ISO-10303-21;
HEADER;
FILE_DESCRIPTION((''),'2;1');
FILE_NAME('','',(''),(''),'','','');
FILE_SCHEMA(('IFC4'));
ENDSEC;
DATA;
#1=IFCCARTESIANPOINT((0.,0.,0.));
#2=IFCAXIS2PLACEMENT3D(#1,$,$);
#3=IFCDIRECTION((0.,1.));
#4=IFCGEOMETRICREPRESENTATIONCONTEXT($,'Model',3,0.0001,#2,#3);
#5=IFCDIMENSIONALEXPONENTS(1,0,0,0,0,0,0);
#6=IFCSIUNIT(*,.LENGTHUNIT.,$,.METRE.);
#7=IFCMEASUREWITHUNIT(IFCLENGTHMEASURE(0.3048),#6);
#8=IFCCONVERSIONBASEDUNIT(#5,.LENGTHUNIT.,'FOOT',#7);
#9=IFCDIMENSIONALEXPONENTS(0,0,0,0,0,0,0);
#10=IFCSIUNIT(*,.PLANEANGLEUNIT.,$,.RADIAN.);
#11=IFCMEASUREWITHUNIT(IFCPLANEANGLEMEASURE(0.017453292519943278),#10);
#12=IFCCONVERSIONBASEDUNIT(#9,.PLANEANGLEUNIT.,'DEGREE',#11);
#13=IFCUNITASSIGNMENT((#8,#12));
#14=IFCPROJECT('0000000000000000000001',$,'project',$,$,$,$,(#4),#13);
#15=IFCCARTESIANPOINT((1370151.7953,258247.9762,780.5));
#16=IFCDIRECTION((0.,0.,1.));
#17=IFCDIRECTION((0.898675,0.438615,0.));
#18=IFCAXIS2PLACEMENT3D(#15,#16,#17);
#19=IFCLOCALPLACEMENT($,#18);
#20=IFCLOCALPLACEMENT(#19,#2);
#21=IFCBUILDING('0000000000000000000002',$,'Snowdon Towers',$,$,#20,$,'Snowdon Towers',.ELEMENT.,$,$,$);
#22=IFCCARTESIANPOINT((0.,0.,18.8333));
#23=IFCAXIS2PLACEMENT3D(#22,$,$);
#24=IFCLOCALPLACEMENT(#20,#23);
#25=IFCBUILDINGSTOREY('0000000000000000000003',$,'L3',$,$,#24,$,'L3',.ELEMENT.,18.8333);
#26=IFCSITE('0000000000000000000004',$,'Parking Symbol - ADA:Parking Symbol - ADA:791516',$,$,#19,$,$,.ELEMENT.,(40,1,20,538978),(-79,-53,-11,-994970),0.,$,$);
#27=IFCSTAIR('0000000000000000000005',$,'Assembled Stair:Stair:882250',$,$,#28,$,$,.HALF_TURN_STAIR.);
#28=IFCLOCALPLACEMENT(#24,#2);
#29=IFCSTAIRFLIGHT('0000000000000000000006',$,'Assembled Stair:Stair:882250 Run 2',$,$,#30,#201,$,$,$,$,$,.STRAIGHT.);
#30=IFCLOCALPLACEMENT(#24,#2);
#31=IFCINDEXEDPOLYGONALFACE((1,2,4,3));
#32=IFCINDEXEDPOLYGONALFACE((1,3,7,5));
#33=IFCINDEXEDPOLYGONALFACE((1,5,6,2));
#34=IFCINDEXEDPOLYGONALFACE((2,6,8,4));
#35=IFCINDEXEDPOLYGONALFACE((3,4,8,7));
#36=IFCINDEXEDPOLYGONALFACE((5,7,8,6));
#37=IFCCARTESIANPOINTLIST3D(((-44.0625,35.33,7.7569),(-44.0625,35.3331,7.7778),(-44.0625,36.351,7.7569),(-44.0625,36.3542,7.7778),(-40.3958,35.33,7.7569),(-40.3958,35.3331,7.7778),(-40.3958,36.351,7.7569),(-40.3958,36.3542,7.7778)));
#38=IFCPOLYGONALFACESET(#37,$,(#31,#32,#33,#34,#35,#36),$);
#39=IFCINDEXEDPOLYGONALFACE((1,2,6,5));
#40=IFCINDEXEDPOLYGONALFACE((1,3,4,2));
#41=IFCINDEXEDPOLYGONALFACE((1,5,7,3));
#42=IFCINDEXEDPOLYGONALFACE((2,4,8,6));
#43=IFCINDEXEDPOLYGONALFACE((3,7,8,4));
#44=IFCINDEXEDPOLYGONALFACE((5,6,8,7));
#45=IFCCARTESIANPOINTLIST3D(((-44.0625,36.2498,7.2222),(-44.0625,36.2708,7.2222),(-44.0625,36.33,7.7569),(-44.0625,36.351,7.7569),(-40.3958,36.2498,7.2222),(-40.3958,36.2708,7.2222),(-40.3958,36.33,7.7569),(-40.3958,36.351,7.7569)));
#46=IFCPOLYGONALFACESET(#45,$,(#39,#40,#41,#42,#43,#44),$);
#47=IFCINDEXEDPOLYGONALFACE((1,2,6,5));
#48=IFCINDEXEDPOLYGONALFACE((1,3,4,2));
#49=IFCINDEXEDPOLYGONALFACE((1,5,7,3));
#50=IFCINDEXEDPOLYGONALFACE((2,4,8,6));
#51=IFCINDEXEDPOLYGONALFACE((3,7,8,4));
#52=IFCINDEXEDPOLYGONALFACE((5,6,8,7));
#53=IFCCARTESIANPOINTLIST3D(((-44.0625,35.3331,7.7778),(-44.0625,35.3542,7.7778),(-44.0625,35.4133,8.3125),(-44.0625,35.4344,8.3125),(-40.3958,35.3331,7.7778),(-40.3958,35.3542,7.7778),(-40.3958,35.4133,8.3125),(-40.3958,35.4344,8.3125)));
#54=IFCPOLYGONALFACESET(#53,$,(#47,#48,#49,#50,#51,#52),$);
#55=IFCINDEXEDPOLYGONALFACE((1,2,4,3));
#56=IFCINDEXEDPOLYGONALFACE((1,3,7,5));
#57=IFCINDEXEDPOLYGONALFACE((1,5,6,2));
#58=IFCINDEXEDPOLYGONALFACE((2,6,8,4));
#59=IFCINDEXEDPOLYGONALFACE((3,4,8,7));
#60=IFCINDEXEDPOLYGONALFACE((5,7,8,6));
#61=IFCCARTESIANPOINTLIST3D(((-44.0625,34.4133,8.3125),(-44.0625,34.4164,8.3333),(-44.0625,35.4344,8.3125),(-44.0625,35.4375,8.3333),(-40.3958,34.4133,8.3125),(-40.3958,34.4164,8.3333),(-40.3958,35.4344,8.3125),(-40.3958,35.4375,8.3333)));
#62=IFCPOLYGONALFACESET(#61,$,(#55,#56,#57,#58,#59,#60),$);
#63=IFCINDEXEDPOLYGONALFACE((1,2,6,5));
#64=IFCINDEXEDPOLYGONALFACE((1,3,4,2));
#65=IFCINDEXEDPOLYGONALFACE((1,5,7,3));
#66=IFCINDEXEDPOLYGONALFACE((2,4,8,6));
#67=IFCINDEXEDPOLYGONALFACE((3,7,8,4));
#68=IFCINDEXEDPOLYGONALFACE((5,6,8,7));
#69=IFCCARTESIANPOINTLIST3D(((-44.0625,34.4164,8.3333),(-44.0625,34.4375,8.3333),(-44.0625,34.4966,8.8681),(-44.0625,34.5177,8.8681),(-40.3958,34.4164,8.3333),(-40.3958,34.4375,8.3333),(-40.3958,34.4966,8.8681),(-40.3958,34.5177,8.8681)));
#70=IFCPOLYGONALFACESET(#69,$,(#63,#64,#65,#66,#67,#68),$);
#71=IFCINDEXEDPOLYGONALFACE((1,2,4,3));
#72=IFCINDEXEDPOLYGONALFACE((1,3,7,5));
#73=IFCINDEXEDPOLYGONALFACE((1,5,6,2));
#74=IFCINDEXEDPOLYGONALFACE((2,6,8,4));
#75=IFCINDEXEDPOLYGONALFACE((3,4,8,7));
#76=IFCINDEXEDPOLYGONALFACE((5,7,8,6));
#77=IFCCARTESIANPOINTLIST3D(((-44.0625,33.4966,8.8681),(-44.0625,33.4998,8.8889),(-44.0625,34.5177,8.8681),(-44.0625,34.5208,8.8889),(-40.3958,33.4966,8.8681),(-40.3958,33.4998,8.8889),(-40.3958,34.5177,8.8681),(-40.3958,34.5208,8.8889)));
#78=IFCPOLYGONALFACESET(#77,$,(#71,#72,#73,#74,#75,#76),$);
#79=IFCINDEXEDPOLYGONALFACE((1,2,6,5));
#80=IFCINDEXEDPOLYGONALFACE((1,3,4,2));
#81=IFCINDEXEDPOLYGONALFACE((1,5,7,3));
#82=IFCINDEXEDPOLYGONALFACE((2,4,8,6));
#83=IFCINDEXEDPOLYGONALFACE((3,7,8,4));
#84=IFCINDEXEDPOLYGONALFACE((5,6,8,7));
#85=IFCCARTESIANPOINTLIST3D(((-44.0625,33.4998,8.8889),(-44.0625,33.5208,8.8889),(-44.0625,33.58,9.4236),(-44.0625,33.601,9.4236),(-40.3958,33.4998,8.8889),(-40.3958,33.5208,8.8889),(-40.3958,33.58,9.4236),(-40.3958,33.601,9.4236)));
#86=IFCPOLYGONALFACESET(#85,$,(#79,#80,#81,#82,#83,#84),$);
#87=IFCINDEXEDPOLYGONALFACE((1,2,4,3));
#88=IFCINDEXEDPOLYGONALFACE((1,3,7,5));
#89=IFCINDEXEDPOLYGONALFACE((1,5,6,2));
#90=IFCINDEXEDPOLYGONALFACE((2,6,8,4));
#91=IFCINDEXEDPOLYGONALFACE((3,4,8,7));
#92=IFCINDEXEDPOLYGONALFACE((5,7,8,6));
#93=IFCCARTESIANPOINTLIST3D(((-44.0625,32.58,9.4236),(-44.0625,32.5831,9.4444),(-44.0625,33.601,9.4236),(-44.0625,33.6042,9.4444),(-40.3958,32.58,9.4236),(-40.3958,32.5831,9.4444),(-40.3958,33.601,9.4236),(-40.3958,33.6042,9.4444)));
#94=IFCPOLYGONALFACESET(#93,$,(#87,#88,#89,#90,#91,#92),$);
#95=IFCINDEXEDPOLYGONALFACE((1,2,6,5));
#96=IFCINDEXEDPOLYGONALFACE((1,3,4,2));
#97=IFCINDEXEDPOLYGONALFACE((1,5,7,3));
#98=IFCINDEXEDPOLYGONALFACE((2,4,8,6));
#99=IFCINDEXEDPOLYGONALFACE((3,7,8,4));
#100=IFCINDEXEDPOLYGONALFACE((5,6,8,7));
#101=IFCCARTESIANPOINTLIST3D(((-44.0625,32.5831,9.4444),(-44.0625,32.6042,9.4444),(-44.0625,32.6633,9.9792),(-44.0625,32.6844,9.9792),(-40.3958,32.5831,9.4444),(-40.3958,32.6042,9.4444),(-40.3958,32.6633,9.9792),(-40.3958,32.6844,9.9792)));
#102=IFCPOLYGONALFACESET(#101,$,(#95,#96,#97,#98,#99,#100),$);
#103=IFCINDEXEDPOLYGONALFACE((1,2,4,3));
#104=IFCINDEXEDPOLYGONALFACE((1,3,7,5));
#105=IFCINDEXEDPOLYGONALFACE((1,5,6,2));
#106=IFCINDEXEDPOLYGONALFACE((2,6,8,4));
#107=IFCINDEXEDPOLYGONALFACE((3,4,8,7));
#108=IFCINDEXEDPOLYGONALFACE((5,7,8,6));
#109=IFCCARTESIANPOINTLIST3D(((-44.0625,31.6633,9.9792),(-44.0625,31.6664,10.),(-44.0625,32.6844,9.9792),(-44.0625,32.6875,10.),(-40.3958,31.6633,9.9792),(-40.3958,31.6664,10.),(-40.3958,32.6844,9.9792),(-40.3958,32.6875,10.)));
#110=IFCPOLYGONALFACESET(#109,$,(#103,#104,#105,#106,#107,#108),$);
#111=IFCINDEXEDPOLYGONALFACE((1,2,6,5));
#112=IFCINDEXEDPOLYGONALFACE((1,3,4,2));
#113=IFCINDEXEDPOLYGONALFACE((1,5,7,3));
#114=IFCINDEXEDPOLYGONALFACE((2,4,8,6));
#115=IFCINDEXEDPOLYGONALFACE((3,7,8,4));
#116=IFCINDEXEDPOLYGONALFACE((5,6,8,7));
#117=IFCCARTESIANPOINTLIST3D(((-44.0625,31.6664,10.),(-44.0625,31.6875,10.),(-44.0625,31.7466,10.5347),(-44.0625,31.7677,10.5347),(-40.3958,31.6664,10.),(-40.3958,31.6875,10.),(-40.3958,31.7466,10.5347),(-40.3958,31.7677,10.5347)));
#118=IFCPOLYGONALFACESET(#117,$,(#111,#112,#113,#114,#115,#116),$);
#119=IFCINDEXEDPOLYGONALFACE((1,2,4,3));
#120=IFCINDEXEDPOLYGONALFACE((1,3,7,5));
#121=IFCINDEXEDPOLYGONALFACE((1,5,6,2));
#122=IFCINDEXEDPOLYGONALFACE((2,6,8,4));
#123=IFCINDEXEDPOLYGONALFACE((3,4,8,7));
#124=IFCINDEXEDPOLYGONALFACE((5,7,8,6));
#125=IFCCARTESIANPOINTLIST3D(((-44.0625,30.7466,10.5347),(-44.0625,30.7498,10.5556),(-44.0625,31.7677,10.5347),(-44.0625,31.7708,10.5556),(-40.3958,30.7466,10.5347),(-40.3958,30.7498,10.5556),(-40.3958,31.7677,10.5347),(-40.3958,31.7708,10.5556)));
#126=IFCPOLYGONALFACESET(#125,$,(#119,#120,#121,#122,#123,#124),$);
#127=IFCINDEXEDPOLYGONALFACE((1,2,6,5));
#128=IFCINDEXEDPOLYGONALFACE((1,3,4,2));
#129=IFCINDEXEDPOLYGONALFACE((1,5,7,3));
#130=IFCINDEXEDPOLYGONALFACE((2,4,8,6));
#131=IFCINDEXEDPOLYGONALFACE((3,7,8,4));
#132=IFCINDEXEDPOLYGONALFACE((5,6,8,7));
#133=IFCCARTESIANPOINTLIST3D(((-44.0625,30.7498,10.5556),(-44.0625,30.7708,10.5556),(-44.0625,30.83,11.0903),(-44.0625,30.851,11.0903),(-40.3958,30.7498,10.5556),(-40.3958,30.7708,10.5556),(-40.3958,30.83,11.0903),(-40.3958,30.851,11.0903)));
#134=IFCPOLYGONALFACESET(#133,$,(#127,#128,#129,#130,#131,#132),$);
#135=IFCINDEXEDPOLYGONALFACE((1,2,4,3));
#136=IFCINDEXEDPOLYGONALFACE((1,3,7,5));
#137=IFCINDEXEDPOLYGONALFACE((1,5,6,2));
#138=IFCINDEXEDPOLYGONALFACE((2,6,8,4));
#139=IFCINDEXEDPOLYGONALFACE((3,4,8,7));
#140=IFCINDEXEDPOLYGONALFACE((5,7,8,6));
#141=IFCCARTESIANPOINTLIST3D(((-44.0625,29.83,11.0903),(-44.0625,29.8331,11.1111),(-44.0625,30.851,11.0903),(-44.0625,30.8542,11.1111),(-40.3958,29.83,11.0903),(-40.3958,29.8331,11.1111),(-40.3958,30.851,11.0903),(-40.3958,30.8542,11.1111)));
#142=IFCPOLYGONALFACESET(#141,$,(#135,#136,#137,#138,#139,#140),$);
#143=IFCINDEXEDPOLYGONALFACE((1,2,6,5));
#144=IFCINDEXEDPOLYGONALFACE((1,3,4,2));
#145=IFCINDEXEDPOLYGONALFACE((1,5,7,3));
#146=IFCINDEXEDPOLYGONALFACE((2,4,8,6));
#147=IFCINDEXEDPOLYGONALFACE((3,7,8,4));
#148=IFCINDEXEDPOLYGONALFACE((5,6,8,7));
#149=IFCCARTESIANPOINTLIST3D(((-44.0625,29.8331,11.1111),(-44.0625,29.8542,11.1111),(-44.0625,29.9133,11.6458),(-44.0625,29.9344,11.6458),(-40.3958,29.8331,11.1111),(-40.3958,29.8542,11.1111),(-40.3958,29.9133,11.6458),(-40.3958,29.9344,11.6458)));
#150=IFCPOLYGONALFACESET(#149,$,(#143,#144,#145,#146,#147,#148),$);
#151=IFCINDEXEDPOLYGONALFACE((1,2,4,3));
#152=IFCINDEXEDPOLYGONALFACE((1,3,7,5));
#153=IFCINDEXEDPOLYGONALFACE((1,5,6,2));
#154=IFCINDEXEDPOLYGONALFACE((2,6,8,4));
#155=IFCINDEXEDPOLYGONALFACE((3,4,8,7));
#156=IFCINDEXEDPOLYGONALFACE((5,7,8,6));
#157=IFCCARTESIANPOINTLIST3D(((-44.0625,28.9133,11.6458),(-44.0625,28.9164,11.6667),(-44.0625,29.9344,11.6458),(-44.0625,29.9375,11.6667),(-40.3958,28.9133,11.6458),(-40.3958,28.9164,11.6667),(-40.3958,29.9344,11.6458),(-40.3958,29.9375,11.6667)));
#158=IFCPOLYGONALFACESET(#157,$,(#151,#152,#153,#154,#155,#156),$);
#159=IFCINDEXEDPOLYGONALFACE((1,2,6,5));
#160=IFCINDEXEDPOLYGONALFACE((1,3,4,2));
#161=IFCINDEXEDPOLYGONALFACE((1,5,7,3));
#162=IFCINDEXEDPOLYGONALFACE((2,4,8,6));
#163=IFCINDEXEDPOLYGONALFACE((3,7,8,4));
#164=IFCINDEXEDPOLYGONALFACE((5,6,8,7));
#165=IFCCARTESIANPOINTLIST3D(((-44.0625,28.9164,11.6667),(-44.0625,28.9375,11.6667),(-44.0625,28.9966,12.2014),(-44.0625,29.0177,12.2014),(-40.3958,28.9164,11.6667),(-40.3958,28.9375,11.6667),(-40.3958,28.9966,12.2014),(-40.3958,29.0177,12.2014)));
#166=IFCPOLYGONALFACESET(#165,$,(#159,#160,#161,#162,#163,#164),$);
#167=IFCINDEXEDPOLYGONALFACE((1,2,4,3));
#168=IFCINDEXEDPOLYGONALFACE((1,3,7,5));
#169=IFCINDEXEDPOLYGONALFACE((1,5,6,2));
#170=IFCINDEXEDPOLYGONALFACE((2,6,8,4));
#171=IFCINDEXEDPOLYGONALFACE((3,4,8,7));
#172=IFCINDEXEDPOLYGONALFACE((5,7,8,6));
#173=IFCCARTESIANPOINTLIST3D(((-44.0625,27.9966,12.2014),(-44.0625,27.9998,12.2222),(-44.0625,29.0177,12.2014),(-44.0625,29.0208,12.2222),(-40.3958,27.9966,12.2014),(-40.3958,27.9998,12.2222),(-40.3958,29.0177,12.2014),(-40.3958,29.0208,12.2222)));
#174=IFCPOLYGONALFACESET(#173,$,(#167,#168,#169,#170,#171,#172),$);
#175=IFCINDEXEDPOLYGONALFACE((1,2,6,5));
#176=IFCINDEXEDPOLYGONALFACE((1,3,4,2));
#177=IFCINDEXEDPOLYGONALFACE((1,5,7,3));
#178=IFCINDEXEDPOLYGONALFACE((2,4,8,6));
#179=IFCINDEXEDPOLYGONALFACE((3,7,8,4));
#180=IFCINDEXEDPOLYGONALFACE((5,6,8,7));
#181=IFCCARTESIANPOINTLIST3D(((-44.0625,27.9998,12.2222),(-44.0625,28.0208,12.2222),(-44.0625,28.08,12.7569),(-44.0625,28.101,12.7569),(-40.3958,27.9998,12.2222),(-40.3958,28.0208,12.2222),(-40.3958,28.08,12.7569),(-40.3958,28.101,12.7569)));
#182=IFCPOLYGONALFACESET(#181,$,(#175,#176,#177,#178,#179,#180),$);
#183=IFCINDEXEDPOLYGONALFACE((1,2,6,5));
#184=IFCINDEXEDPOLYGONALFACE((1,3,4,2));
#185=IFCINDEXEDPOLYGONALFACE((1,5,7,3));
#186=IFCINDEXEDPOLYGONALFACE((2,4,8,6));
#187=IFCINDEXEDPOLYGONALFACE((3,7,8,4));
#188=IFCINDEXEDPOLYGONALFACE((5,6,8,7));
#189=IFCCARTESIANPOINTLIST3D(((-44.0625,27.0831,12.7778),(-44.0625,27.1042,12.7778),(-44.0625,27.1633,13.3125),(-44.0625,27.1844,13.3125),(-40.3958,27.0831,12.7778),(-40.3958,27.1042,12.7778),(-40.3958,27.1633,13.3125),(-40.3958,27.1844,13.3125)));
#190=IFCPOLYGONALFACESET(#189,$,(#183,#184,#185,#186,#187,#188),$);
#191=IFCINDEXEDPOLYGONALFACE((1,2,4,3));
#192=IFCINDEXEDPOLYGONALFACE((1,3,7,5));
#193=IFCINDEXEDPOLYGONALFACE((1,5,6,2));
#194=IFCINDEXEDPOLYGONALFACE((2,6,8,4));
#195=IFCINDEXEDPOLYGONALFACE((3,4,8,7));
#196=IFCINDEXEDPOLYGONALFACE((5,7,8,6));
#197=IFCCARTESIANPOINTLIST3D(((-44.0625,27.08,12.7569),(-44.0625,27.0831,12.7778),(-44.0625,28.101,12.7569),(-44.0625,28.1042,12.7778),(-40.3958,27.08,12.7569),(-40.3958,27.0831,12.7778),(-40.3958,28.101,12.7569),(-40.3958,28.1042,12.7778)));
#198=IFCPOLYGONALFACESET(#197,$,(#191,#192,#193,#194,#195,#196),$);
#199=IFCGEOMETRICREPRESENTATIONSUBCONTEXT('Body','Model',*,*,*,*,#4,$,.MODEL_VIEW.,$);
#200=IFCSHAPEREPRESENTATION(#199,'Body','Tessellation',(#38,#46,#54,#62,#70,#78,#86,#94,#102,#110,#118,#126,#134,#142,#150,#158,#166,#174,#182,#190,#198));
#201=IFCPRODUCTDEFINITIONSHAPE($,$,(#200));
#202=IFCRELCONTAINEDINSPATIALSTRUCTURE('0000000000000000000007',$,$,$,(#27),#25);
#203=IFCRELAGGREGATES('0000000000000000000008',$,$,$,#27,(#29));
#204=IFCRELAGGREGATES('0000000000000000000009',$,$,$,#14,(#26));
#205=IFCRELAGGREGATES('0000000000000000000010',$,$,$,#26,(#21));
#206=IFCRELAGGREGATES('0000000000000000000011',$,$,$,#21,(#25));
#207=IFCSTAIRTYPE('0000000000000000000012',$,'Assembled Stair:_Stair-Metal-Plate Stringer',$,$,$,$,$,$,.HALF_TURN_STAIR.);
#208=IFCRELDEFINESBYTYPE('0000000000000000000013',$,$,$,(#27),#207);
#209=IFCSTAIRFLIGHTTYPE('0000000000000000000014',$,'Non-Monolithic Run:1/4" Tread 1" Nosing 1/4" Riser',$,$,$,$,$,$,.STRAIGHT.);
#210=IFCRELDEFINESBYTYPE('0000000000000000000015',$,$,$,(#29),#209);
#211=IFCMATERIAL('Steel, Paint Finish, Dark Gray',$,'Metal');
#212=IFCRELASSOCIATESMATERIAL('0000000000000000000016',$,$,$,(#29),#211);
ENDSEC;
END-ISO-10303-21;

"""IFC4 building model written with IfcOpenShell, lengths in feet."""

from ifc_helpers import new_model, entity, si_unit, converted_unit, direction, frame, origin, place, context, subcontext, project, spatial, indexed_curve, outline, extrude, material, type_object, element, aggregate, save


model = new_model("IFC4")

# Units and contexts
model_context = context("Model", 3, precision=0.0001, world=origin(), true_north=direction((0.0, 1.0)))
body_context = subcontext(model_context, "Body", "Model", "MODEL_VIEW")
ifc_project = project(units=[converted_unit("LENGTHUNIT", "FOOT", entity("IfcLengthMeasure", 0.3048), si_unit("LENGTHUNIT", "METRE"), dimensions=[1, 0, 0, 0, 0, 0, 0]), converted_unit("PLANEANGLEUNIT", "DEGREE", entity("IfcPlaneAngleMeasure", 0.017453292519943278), si_unit("PLANEANGLEUNIT", "RADIAN"), dimensions=[0, 0, 0, 0, 0, 0, 0])], contexts=[model_context])

# Site, building, storey
site_placement = place(None, frame((1370151.7953, 258247.9762, 780.5), z_axis=(0.0, 0.0, 1.0), x_axis=(0.898675, 0.438615, 0.0)))
site = spatial("IfcSite", under=ifc_project, at=site_placement, Name="Parking Symbol - ADA:Parking Symbol - ADA:791516", CompositionType="ELEMENT", RefLatitude=(40, 1, 20, 538978), RefLongitude=(-79, -53, -11, -994970), RefElevation=0.0)
building_placement = place(site_placement, origin())
building = spatial("IfcBuilding", under=site, at=building_placement, Name="Snowdon Towers", LongName="Snowdon Towers", CompositionType="ELEMENT")
storey_placement = place(building_placement, frame((0.0, 0.0, 18.8333)))
storey = spatial("IfcBuildingStorey", under=building, at=storey_placement, Name="L3", LongName="L3", CompositionType="ELEMENT", Elevation=18.8333)

# Stair
stair_type = type_object("IfcStairType", Name="Assembled Stair:_Stair-Metal-Plate Stringer", PredefinedType="HALF_TURN_STAIR")
ifc_material_1 = material(Name="Steel, Paint Finish, Dark Gray", Category="Metal")
stair_1_placement = place(storey_placement, origin())
stair_1 = element("IfcStair", 1, at=stair_1_placement, inside=storey, type_object=stair_type, Name="Assembled Stair:Stair:882250", PredefinedType="HALF_TURN_STAIR")

# Stair flight
stair_flight_type = type_object("IfcStairFlightType", Name="Non-Monolithic Run:1/4\" Tread 1\" Nosing 1/4\" Riser", PredefinedType="STRAIGHT")
stair_flight_1_placement = place(stair_1_placement, origin())
stair_flight_1 = element("IfcStairFlight", 2, at=stair_flight_1_placement, type_object=stair_flight_type, material=ifc_material_1, Name="Assembled Stair:Stair:882250 Run 2", PredefinedType="STRAIGHT", context=body_context, shape_type="SweptSolid", body=[
    extrude(outline(indexed_curve([(0.0652, -0.5049), (0.0863, -0.5049), (-0.0652, 0.5049), (-0.0863, 0.5049), (0.0652, -0.5049)], self_intersect=False)), frame((-44.0625, 35.8421, 7.7674), z_axis=(1.0, 0.0, 0.0), x_axis=(0.0, -0.14834, -0.988936)), (0.0, 0.0, 1.0), 3.6667),
    extrude(outline(indexed_curve([(-0.0506, -0.2674), (-0.0296, -0.2674), (0.0506, 0.2674), (0.0296, 0.2674), (-0.0506, -0.2674)], self_intersect=False)), frame((-44.0625, 36.3004, 7.4896), z_axis=(1.0, 0.0, 0.0), x_axis=(0.0, -1.0, 0.0)), (0.0, 0.0, 1.0), 3.6667),
    extrude(outline(indexed_curve([(-0.0506, -0.2674), (-0.0296, -0.2674), (0.0506, 0.2674), (0.0296, 0.2674), (-0.0506, -0.2674)], self_intersect=False)), frame((-44.0625, 35.3837, 8.0451), z_axis=(1.0, 0.0, 0.0), x_axis=(0.0, -1.0, 0.0)), (0.0, 0.0, 1.0), 3.6667),
    extrude(outline(indexed_curve([(0.0652, -0.5049), (0.0863, -0.5049), (-0.0652, 0.5049), (-0.0863, 0.5049), (0.0652, -0.5049)], self_intersect=False)), frame((-44.0625, 34.9254, 8.3229), z_axis=(1.0, 0.0, 0.0), x_axis=(0.0, -0.14834, -0.988936)), (0.0, 0.0, 1.0), 3.6667),
    extrude(outline(indexed_curve([(-0.0506, -0.2674), (-0.0296, -0.2674), (0.0506, 0.2674), (0.0296, 0.2674), (-0.0506, -0.2674)], self_intersect=False)), frame((-44.0625, 34.4671, 8.6007), z_axis=(1.0, 0.0, 0.0), x_axis=(0.0, -1.0, 0.0)), (0.0, 0.0, 1.0), 3.6667),
    extrude(outline(indexed_curve([(0.0652, -0.5049), (0.0863, -0.5049), (-0.0652, 0.5049), (-0.0863, 0.5049), (0.0652, -0.5049)], self_intersect=False)), frame((-44.0625, 34.0087, 8.8785), z_axis=(1.0, 0.0, 0.0), x_axis=(0.0, -0.14834, -0.988936)), (0.0, 0.0, 1.0), 3.6667),
    extrude(outline(indexed_curve([(-0.0506, -0.2674), (-0.0296, -0.2674), (0.0506, 0.2674), (0.0296, 0.2674), (-0.0506, -0.2674)], self_intersect=False)), frame((-44.0625, 33.5504, 9.1562), z_axis=(1.0, 0.0, 0.0), x_axis=(0.0, -1.0, 0.0)), (0.0, 0.0, 1.0), 3.6667),
    extrude(outline(indexed_curve([(0.0652, -0.5049), (0.0863, -0.5049), (-0.0652, 0.5049), (-0.0863, 0.5049), (0.0652, -0.5049)], self_intersect=False)), frame((-44.0625, 33.0921, 9.434), z_axis=(1.0, 0.0, 0.0), x_axis=(0.0, -0.14834, -0.988936)), (0.0, 0.0, 1.0), 3.6667),
    extrude(outline(indexed_curve([(-0.0506, -0.2674), (-0.0296, -0.2674), (0.0506, 0.2674), (0.0296, 0.2674), (-0.0506, -0.2674)], self_intersect=False)), frame((-44.0625, 32.6337, 9.7118), z_axis=(1.0, 0.0, 0.0), x_axis=(0.0, -1.0, 0.0)), (0.0, 0.0, 1.0), 3.6667),
    extrude(outline(indexed_curve([(0.0652, -0.5049), (0.0863, -0.5049), (-0.0652, 0.5049), (-0.0863, 0.5049), (0.0652, -0.5049)], self_intersect=False)), frame((-44.0625, 32.1754, 9.9896), z_axis=(1.0, 0.0, 0.0), x_axis=(0.0, -0.14834, -0.988936)), (0.0, 0.0, 1.0), 3.6667),
    extrude(outline(indexed_curve([(-0.0506, -0.2674), (-0.0296, -0.2674), (0.0506, 0.2674), (0.0296, 0.2674), (-0.0506, -0.2674)], self_intersect=False)), frame((-44.0625, 31.7171, 10.2674), z_axis=(1.0, 0.0, 0.0), x_axis=(0.0, -1.0, 0.0)), (0.0, 0.0, 1.0), 3.6667),
    extrude(outline(indexed_curve([(0.0652, -0.5049), (0.0863, -0.5049), (-0.0652, 0.5049), (-0.0863, 0.5049), (0.0652, -0.5049)], self_intersect=False)), frame((-44.0625, 31.2587, 10.5451), z_axis=(1.0, 0.0, 0.0), x_axis=(0.0, -0.14834, -0.988936)), (0.0, 0.0, 1.0), 3.6667),
    extrude(outline(indexed_curve([(-0.0506, -0.2674), (-0.0296, -0.2674), (0.0506, 0.2674), (0.0296, 0.2674), (-0.0506, -0.2674)], self_intersect=False)), frame((-44.0625, 30.8004, 10.8229), z_axis=(1.0, 0.0, 0.0), x_axis=(0.0, -1.0, 0.0)), (0.0, 0.0, 1.0), 3.6667),
    extrude(outline(indexed_curve([(0.0652, -0.5049), (0.0863, -0.5049), (-0.0652, 0.5049), (-0.0863, 0.5049), (0.0652, -0.5049)], self_intersect=False)), frame((-44.0625, 30.3421, 11.1007), z_axis=(1.0, 0.0, 0.0), x_axis=(0.0, -0.14834, -0.988936)), (0.0, 0.0, 1.0), 3.6667),
    extrude(outline(indexed_curve([(-0.0506, -0.2674), (-0.0296, -0.2674), (0.0506, 0.2674), (0.0296, 0.2674), (-0.0506, -0.2674)], self_intersect=False)), frame((-44.0625, 29.8837, 11.3785), z_axis=(1.0, 0.0, 0.0), x_axis=(0.0, -1.0, 0.0)), (0.0, 0.0, 1.0), 3.6667),
    extrude(outline(indexed_curve([(0.0652, -0.5049), (0.0863, -0.5049), (-0.0652, 0.5049), (-0.0863, 0.5049), (0.0652, -0.5049)], self_intersect=False)), frame((-44.0625, 29.4254, 11.6563), z_axis=(1.0, 0.0, 0.0), x_axis=(0.0, -0.14834, -0.988936)), (0.0, 0.0, 1.0), 3.6667),
    extrude(outline(indexed_curve([(-0.0506, -0.2674), (-0.0296, -0.2674), (0.0506, 0.2674), (0.0296, 0.2674), (-0.0506, -0.2674)], self_intersect=False)), frame((-44.0625, 28.9671, 11.934), z_axis=(1.0, 0.0, 0.0), x_axis=(0.0, -1.0, 0.0)), (0.0, 0.0, 1.0), 3.6667),
    extrude(outline(indexed_curve([(0.0652, -0.5049), (0.0863, -0.5049), (-0.0652, 0.5049), (-0.0863, 0.5049), (0.0652, -0.5049)], self_intersect=False)), frame((-44.0625, 28.5087, 12.2118), z_axis=(1.0, 0.0, 0.0), x_axis=(0.0, -0.14834, -0.988936)), (0.0, 0.0, 1.0), 3.6667),
    extrude(outline(indexed_curve([(-0.0506, -0.2674), (-0.0296, -0.2674), (0.0506, 0.2674), (0.0296, 0.2674), (-0.0506, -0.2674)], self_intersect=False)), frame((-44.0625, 28.0504, 12.4896), z_axis=(1.0, 0.0, 0.0), x_axis=(0.0, -1.0, 0.0)), (0.0, 0.0, 1.0), 3.6667),
    extrude(outline(indexed_curve([(-0.0506, -0.2674), (-0.0296, -0.2674), (0.0506, 0.2674), (0.0296, 0.2674), (-0.0506, -0.2674)], self_intersect=False)), frame((-44.0625, 27.1337, 13.0451), z_axis=(1.0, 0.0, 0.0), x_axis=(0.0, -1.0, 0.0)), (0.0, 0.0, 1.0), 3.6667),
    extrude(outline(indexed_curve([(0.0652, -0.5049), (0.0863, -0.5049), (-0.0652, 0.5049), (-0.0863, 0.5049), (0.0652, -0.5049)], self_intersect=False)), frame((-44.0625, 27.5921, 12.7674), z_axis=(1.0, 0.0, 0.0), x_axis=(0.0, -0.14834, -0.988936)), (0.0, 0.0, 1.0), 3.6667),
])
aggregate(stair_1, [stair_flight_1])

save(model, "model.ifc")
